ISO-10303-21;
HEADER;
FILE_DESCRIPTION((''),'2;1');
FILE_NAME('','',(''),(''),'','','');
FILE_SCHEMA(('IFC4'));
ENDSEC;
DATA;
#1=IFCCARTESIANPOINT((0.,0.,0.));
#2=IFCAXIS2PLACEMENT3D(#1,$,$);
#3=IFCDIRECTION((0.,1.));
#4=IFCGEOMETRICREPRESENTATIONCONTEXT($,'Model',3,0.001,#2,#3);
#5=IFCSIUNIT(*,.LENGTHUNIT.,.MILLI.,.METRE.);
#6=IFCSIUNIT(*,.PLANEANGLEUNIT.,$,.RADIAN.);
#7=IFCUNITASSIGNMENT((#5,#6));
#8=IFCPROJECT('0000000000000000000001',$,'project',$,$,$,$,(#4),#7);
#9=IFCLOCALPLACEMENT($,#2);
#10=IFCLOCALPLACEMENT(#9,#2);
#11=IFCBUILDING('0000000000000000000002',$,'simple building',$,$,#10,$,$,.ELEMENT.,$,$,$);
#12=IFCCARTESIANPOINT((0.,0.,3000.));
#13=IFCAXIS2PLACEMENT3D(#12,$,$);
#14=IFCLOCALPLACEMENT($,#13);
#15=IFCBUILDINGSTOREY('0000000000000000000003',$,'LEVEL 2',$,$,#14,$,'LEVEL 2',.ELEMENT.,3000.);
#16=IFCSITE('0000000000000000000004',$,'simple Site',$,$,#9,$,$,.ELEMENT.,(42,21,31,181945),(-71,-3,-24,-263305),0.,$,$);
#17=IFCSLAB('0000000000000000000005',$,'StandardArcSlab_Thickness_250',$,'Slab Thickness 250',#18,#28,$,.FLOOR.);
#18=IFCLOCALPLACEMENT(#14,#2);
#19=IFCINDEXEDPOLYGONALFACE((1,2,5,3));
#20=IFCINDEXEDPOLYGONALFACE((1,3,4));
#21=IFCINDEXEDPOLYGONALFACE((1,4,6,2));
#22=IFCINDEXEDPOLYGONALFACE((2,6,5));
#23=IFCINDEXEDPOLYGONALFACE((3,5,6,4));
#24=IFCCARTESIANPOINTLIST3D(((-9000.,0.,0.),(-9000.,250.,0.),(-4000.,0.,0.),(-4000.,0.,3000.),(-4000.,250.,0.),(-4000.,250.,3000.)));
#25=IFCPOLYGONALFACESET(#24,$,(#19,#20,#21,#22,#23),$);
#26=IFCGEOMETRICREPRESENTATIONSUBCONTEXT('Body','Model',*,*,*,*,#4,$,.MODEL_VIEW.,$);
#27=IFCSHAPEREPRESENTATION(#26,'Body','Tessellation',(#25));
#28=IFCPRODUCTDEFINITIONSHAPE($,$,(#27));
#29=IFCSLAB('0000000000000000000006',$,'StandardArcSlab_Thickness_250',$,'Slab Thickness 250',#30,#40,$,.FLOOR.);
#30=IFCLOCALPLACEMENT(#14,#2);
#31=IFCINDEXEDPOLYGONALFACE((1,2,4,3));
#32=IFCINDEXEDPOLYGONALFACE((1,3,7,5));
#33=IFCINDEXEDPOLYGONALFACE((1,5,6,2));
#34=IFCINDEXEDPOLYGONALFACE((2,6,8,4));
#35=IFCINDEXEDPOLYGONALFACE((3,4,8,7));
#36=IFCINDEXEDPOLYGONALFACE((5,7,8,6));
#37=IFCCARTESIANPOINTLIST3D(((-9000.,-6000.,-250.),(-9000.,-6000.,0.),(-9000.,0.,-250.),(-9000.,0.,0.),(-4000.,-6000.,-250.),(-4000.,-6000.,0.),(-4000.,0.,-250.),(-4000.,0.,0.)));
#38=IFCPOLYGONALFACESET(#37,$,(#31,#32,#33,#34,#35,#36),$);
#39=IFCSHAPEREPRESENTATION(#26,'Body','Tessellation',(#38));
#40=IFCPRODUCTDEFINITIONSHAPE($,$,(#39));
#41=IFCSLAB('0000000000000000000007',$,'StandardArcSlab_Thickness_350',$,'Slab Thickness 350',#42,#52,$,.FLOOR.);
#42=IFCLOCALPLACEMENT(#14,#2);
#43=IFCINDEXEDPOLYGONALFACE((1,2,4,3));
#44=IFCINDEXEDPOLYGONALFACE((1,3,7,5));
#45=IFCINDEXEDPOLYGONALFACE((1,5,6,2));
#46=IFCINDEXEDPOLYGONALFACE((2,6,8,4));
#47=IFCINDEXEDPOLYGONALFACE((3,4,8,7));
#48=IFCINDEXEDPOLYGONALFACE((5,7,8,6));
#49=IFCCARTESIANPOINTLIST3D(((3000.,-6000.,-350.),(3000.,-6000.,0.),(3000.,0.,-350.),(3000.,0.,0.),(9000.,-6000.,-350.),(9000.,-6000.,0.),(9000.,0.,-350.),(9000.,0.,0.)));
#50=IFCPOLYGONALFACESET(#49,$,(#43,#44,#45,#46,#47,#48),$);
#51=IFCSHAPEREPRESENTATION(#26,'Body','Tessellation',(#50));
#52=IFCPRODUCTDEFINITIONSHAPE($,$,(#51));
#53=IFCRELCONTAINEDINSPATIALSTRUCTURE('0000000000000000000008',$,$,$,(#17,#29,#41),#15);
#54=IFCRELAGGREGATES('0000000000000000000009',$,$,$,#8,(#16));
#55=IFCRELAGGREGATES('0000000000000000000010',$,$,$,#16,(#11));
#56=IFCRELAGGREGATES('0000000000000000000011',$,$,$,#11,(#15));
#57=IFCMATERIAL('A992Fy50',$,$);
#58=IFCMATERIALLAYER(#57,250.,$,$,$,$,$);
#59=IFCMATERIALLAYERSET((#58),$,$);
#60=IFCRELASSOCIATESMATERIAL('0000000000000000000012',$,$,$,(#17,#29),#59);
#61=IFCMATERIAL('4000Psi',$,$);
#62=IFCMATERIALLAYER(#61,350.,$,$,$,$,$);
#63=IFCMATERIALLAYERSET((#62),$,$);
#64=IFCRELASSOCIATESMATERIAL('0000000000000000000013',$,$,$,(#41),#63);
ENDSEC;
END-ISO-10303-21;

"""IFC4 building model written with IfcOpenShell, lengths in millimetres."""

from ifc_helpers import new_model, si_unit, direction, frame, origin, origin_with_axes, place, context, subcontext, project, spatial, polyline, outline, extrude, material, layer, layer_set, layer_usage, element, save


model = new_model("IFC4")

# Units and contexts
model_context = context("Model", 3, precision=0.001, world=origin(), true_north=direction((0.0, 1.0)))
body_context = subcontext(model_context, "Body", "Model", "MODEL_VIEW")
ifc_project = project(units=[si_unit("LENGTHUNIT", "METRE", prefix="MILLI"), si_unit("PLANEANGLEUNIT", "RADIAN")], contexts=[model_context])

# Site, building, storey
site_placement = place(None, origin())
site = spatial("IfcSite", under=ifc_project, at=site_placement, Name="simple Site", CompositionType="ELEMENT", RefLatitude=(42, 21, 31, 181945), RefLongitude=(-71, -3, -24, -263305), RefElevation=0.0)
building_placement = place(site_placement, origin())
building = spatial("IfcBuilding", under=site, at=building_placement, Name="simple building", CompositionType="ELEMENT")
storey_placement = place(None, frame((0.0, 0.0, 3000.0)))
storey = spatial("IfcBuildingStorey", under=building, at=storey_placement, Name="LEVEL 2", LongName="LEVEL 2", CompositionType="ELEMENT", Elevation=3000.0)

# Shared definitions
ifc_material_1 = material(Name="4000Psi")

# Slabs
ifc_material_2 = material(Name="A992Fy50")
ifc_layer_1 = layer(ifc_material_2, 250.0)
ifc_layer_set_1 = layer_set([ifc_layer_1])
ifc_layer_usage_1 = layer_usage(ifc_layer_set_1, "AXIS3", "POSITIVE", -250.0)
slab_1_placement = place(None, frame((-9000.0, 250.0, 3000.0), z_axis=(0.0, -1.0, 0.0), x_axis=(1.0, 0.0, 0.0)))
element("IfcSlab", 1, at=slab_1_placement, inside=storey, material=ifc_layer_usage_1, Name="StandardArcSlab_Thickness_250", ObjectType="Slab Thickness 250", PredefinedType="FLOOR", context=body_context, shape_type="SweptSolid", body=[
    extrude(outline(polyline([(0.0, 0.0), (5000.0, 0.0), (5000.0, 3000.0), (0.0, 0.0)])), origin_with_axes(), (0.0, 0.0, 1.0), 250.0),
])
slab_2_placement = place(None, frame((-9000.0, 0.0, 2750.0), z_axis=(0.0, 0.0, 1.0), x_axis=(0.0, -1.0, 0.0)))
element("IfcSlab", 2, at=slab_2_placement, inside=storey, material=ifc_layer_usage_1, Name="StandardArcSlab_Thickness_250", ObjectType="Slab Thickness 250", PredefinedType="FLOOR", context=body_context, shape_type="SweptSolid", body=[
    extrude(outline(polyline([(0.0, 0.0), (6000.0, 0.0), (6000.0, 5000.0), (0.0, 5000.0), (0.0, 0.0)])), origin_with_axes(), (0.0, 0.0, 1.0), 250.0),
])
ifc_layer_2 = layer(ifc_material_1, 350.0)
ifc_layer_set_2 = layer_set([ifc_layer_2])
ifc_layer_usage_2 = layer_usage(ifc_layer_set_2, "AXIS3", "POSITIVE", -350.0)
slab_3_placement = place(None, frame((3000.0, -6000.0, 2650.0), z_axis=(0.0, 0.0, 1.0), x_axis=(1.0, 0.0, 0.0)))
element("IfcSlab", 3, at=slab_3_placement, inside=storey, material=ifc_layer_usage_2, Name="StandardArcSlab_Thickness_350", ObjectType="Slab Thickness 350", PredefinedType="FLOOR", context=body_context, shape_type="SweptSolid", body=[
    extrude(outline(polyline([(0.0, 0.0), (6000.0, 0.0), (6000.0, 6000.0), (0.0, 6000.0), (0.0, 0.0)])), origin_with_axes(), (0.0, 0.0, 1.0), 350.0),
])

save(model, "model.ifc")
